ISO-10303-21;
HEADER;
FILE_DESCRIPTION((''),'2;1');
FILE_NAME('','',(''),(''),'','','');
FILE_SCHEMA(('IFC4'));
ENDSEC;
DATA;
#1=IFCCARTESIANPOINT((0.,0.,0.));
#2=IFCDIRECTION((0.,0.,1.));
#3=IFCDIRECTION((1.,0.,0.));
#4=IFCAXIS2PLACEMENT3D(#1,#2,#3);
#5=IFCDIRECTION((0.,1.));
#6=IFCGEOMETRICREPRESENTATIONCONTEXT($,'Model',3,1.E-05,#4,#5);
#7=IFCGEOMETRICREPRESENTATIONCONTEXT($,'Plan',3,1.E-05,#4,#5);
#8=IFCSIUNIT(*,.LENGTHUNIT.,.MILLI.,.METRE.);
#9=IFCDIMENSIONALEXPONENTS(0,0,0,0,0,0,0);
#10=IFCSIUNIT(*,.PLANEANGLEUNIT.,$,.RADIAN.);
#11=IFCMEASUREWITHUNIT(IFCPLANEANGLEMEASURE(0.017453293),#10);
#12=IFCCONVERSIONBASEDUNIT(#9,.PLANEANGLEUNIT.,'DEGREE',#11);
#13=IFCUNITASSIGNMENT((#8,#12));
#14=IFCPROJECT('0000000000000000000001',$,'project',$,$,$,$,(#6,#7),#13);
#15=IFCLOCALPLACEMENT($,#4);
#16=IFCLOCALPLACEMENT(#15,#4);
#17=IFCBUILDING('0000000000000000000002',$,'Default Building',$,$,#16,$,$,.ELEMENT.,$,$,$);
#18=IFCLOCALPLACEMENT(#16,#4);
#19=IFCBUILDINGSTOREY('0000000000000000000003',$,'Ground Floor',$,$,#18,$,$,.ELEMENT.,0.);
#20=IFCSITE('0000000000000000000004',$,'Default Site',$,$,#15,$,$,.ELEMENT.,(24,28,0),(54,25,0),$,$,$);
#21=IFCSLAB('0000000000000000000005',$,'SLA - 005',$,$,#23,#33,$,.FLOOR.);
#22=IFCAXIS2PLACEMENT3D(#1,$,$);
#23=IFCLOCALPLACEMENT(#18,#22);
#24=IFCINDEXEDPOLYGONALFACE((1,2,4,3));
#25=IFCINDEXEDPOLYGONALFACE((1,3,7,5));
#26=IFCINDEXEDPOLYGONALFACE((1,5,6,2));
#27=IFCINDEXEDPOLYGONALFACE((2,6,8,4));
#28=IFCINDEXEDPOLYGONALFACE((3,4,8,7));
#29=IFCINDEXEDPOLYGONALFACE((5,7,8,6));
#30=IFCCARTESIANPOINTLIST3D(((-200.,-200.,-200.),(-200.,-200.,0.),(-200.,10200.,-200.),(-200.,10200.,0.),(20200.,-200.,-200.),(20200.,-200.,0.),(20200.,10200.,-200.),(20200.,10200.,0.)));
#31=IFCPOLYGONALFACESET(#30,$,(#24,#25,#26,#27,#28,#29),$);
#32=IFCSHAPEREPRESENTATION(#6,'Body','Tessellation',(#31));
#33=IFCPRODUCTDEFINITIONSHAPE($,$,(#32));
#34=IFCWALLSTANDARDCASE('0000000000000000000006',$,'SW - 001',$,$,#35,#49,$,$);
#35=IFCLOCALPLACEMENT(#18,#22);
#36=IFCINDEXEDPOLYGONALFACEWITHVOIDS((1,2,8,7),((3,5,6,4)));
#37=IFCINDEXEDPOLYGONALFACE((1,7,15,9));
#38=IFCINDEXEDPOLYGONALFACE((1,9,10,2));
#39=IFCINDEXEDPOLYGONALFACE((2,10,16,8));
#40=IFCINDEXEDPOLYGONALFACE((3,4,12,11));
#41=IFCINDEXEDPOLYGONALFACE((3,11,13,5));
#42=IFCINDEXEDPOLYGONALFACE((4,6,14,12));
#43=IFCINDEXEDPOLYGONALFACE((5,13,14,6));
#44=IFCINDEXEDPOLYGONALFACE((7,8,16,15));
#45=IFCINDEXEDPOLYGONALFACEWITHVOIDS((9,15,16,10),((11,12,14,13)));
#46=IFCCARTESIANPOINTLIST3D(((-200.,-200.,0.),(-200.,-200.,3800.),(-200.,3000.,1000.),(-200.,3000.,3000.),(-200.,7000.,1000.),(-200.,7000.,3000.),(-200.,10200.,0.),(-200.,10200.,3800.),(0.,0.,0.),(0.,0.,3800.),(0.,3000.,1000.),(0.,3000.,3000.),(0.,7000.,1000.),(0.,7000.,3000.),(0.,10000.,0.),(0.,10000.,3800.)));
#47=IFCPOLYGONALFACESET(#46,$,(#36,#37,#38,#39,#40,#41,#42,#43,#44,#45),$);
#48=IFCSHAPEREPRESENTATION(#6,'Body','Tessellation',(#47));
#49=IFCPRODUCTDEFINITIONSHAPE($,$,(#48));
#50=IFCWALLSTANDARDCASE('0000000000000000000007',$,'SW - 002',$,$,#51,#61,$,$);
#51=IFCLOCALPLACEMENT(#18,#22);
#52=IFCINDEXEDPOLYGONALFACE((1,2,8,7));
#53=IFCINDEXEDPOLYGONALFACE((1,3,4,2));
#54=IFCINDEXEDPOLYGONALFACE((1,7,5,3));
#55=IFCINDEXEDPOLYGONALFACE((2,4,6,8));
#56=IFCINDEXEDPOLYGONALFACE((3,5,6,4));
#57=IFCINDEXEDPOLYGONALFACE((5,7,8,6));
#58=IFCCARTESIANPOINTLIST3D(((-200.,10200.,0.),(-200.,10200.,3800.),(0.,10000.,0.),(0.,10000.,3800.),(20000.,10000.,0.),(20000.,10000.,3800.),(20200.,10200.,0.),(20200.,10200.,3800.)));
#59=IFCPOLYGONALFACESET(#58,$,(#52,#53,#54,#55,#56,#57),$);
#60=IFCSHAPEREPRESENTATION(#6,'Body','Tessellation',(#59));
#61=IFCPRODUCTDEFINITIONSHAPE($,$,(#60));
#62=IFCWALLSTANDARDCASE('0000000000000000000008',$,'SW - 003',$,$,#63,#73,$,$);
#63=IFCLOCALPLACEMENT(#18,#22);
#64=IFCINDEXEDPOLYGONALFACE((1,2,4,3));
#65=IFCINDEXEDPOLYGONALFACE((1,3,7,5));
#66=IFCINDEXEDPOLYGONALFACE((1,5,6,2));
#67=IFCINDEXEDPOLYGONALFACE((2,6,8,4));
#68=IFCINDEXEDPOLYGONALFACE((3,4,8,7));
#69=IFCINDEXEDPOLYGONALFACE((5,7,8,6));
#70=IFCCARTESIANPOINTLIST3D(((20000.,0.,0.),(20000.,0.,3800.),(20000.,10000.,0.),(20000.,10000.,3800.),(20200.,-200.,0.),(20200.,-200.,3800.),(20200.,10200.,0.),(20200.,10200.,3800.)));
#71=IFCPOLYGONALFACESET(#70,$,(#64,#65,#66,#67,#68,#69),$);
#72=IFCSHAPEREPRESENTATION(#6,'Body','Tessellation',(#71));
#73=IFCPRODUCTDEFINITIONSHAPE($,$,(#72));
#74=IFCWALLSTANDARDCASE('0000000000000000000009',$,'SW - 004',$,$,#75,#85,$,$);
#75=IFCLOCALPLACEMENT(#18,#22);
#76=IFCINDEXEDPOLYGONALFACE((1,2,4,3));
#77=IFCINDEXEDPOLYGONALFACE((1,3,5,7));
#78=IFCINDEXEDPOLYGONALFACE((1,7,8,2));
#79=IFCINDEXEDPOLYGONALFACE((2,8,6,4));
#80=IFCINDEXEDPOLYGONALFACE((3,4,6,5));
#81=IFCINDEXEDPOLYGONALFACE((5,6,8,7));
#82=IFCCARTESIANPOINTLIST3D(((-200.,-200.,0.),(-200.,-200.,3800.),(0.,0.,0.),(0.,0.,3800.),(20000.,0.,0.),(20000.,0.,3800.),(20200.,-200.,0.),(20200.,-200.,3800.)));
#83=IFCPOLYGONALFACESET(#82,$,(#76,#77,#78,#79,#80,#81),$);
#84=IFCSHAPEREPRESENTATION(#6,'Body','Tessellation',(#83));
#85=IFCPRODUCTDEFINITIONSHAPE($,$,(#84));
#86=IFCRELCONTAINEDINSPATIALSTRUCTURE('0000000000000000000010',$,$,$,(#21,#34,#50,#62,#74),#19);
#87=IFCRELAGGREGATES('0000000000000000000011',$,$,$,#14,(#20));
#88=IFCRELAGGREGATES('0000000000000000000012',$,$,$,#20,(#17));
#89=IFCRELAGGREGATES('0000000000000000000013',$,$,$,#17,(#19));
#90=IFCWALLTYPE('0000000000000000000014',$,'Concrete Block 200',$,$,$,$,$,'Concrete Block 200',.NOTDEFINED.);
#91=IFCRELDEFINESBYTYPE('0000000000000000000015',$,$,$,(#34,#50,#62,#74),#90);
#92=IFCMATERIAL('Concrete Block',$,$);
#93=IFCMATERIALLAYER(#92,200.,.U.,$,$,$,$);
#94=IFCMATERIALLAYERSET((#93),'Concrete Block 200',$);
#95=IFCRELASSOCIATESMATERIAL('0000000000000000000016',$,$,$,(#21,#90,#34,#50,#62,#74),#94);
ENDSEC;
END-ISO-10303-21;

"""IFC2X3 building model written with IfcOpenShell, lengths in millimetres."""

from ifc_helpers import new_model, entity, si_unit, converted_unit, direction, frame, frame_2d, origin_with_axes, place, context, project, spatial, polyline, rectangle, outline, extrude, material, layer, layer_set, layer_usage, type_object, element, save


model = new_model("IFC2X3")

# Units and contexts
model_context = context("Model", 3, precision=1e-05, world=origin_with_axes(), true_north=direction((0.0, 1.0)))
plan_context = context("Plan", 3, precision=1e-05, world=origin_with_axes(), true_north=direction((0.0, 1.0)))
ifc_project = project(units=[si_unit("LENGTHUNIT", "METRE", prefix="MILLI"), converted_unit("PLANEANGLEUNIT", "DEGREE", entity("IfcPlaneAngleMeasure", 0.017453293), si_unit("PLANEANGLEUNIT", "RADIAN"), dimensions=[0, 0, 0, 0, 0, 0, 0])], contexts=[model_context, plan_context])

# Site, building, storey
site_placement = place(None, origin_with_axes())
site = spatial("IfcSite", under=ifc_project, at=site_placement, Name="Default Site", CompositionType="ELEMENT", RefLatitude=(24, 28, 0), RefLongitude=(54, 25, 0))
building_placement = place(site_placement, origin_with_axes())
building = spatial("IfcBuilding", under=site, at=building_placement, Name="Default Building", CompositionType="ELEMENT")
storey_placement = place(building_placement, origin_with_axes())
storey = spatial("IfcBuildingStorey", under=building, at=storey_placement, Name="Ground Floor", CompositionType="ELEMENT", Elevation=0.0)

# Slab
ifc_material = material(Name="Concrete Block")
ifc_layer = layer(ifc_material, 200.0, ventilated="UNKNOWN")
ifc_layer_set = layer_set([ifc_layer], Name="Concrete Block 200")
ifc_layer_usage_1 = layer_usage(ifc_layer_set, "AXIS3", "NEGATIVE", 200.0)
slab_placement = place(storey_placement, frame((-200.0, 10200.0, -200.0), z_axis=(0.0, 0.0, 1.0), x_axis=(1.0, 0.0, 0.0)))
element("IfcSlab", 1, at=slab_placement, inside=storey, material=ifc_layer_usage_1, Name="SLA - 005", PredefinedType="FLOOR", context=model_context, shape_type="SweptSolid", body=[
    extrude(outline(polyline([(0.0, 0.0), (20400.0, 0.0), (20400.0, -10400.0), (0.0, -10400.0), (0.0, 0.0)])), origin_with_axes(), (0.0, 0.0, 1.0), 200.0),
])

# Wall, opening
ifc_layer_usage_2 = layer_usage(ifc_layer_set, "AXIS2", "POSITIVE", 0.0)
wall_type = type_object("IfcWallType", Name="Concrete Block 200", ElementType="Concrete Block 200", PredefinedType="NOTDEFINED", material=ifc_layer_set)
wall_1_placement = place(storey_placement, frame((0.0, 0.0, 0.0), z_axis=(0.0, 0.0, 1.0), x_axis=(0.0, 1.0, 0.0)))
wall_1 = element("IfcWallStandardCase", 2, at=wall_1_placement, inside=storey, type_object=wall_type, material=ifc_layer_usage_2, Name="SW - 001", context=model_context, shape_type="SweptSolid", body=[
    extrude(outline(polyline([(0.0, 0.0), (10000.0, 0.0), (10200.0, 200.0), (-200.0, 200.0), (0.0, 0.0)])), origin_with_axes(), (0.0, 0.0, 1.0), 3800.0),
])
opening_placement = place(wall_1_placement, frame((5000.0, 0.0, 1000.0), z_axis=(0.0, 0.0, 1.0), x_axis=(1.0, 0.0, 0.0)))
element("IfcOpeningElement", 3, at=opening_placement, cuts=wall_1, ObjectType="Opening", context=model_context, shape_type="SweptSolid", body=[
    extrude(rectangle(XDim=4000.0, YDim=2000.0, at=frame_2d((0.0, 1000.0), x_axis=(-1.0, 0.0))), frame((0.0, 0.0, 0.0), z_axis=(0.0, 1.0, 0.0), x_axis=(-1.0, 0.0, 0.0)), (0.0, 0.0, 1.0), 200.0),
])

# Walls
ifc_layer_usage_3 = layer_usage(ifc_layer_set, "AXIS2", "POSITIVE", 0.0)
wall_2_placement = place(storey_placement, frame((0.0, 10000.0, 0.0), z_axis=(0.0, 0.0, 1.0), x_axis=(1.0, 0.0, 0.0)))
element("IfcWallStandardCase", 4, at=wall_2_placement, inside=storey, type_object=wall_type, material=ifc_layer_usage_3, Name="SW - 002", context=model_context, shape_type="SweptSolid", body=[
    extrude(outline(polyline([(0.0, 0.0), (20000.0, 0.0), (20200.0, 200.0), (-200.0, 200.0), (0.0, 0.0)])), origin_with_axes(), (0.0, 0.0, 1.0), 3800.0),
])
ifc_layer_usage_4 = layer_usage(ifc_layer_set, "AXIS2", "POSITIVE", 0.0)
wall_3_placement = place(storey_placement, frame((20000.0, 10000.0, 0.0), z_axis=(0.0, 0.0, 1.0), x_axis=(0.0, -1.0, 0.0)))
element("IfcWallStandardCase", 5, at=wall_3_placement, inside=storey, type_object=wall_type, material=ifc_layer_usage_4, Name="SW - 003", context=model_context, shape_type="SweptSolid", body=[
    extrude(outline(polyline([(0.0, 0.0), (10000.0, 0.0), (10200.0, 200.0), (-200.0, 200.0), (0.0, 0.0)])), origin_with_axes(), (0.0, 0.0, 1.0), 3800.0),
])
ifc_layer_usage_5 = layer_usage(ifc_layer_set, "AXIS2", "POSITIVE", 0.0)
wall_4_placement = place(storey_placement, frame((20000.0, 0.0, 0.0), z_axis=(0.0, 0.0, 1.0), x_axis=(-1.0, 0.0, 0.0)))
element("IfcWallStandardCase", 6, at=wall_4_placement, inside=storey, type_object=wall_type, material=ifc_layer_usage_5, Name="SW - 004", context=model_context, shape_type="SweptSolid", body=[
    extrude(outline(polyline([(0.0, 0.0), (20000.0, 0.0), (20200.0, 200.0), (-200.0, 200.0), (0.0, 0.0)])), origin_with_axes(), (0.0, 0.0, 1.0), 3800.0),
])

save(model, "model.ifc")
